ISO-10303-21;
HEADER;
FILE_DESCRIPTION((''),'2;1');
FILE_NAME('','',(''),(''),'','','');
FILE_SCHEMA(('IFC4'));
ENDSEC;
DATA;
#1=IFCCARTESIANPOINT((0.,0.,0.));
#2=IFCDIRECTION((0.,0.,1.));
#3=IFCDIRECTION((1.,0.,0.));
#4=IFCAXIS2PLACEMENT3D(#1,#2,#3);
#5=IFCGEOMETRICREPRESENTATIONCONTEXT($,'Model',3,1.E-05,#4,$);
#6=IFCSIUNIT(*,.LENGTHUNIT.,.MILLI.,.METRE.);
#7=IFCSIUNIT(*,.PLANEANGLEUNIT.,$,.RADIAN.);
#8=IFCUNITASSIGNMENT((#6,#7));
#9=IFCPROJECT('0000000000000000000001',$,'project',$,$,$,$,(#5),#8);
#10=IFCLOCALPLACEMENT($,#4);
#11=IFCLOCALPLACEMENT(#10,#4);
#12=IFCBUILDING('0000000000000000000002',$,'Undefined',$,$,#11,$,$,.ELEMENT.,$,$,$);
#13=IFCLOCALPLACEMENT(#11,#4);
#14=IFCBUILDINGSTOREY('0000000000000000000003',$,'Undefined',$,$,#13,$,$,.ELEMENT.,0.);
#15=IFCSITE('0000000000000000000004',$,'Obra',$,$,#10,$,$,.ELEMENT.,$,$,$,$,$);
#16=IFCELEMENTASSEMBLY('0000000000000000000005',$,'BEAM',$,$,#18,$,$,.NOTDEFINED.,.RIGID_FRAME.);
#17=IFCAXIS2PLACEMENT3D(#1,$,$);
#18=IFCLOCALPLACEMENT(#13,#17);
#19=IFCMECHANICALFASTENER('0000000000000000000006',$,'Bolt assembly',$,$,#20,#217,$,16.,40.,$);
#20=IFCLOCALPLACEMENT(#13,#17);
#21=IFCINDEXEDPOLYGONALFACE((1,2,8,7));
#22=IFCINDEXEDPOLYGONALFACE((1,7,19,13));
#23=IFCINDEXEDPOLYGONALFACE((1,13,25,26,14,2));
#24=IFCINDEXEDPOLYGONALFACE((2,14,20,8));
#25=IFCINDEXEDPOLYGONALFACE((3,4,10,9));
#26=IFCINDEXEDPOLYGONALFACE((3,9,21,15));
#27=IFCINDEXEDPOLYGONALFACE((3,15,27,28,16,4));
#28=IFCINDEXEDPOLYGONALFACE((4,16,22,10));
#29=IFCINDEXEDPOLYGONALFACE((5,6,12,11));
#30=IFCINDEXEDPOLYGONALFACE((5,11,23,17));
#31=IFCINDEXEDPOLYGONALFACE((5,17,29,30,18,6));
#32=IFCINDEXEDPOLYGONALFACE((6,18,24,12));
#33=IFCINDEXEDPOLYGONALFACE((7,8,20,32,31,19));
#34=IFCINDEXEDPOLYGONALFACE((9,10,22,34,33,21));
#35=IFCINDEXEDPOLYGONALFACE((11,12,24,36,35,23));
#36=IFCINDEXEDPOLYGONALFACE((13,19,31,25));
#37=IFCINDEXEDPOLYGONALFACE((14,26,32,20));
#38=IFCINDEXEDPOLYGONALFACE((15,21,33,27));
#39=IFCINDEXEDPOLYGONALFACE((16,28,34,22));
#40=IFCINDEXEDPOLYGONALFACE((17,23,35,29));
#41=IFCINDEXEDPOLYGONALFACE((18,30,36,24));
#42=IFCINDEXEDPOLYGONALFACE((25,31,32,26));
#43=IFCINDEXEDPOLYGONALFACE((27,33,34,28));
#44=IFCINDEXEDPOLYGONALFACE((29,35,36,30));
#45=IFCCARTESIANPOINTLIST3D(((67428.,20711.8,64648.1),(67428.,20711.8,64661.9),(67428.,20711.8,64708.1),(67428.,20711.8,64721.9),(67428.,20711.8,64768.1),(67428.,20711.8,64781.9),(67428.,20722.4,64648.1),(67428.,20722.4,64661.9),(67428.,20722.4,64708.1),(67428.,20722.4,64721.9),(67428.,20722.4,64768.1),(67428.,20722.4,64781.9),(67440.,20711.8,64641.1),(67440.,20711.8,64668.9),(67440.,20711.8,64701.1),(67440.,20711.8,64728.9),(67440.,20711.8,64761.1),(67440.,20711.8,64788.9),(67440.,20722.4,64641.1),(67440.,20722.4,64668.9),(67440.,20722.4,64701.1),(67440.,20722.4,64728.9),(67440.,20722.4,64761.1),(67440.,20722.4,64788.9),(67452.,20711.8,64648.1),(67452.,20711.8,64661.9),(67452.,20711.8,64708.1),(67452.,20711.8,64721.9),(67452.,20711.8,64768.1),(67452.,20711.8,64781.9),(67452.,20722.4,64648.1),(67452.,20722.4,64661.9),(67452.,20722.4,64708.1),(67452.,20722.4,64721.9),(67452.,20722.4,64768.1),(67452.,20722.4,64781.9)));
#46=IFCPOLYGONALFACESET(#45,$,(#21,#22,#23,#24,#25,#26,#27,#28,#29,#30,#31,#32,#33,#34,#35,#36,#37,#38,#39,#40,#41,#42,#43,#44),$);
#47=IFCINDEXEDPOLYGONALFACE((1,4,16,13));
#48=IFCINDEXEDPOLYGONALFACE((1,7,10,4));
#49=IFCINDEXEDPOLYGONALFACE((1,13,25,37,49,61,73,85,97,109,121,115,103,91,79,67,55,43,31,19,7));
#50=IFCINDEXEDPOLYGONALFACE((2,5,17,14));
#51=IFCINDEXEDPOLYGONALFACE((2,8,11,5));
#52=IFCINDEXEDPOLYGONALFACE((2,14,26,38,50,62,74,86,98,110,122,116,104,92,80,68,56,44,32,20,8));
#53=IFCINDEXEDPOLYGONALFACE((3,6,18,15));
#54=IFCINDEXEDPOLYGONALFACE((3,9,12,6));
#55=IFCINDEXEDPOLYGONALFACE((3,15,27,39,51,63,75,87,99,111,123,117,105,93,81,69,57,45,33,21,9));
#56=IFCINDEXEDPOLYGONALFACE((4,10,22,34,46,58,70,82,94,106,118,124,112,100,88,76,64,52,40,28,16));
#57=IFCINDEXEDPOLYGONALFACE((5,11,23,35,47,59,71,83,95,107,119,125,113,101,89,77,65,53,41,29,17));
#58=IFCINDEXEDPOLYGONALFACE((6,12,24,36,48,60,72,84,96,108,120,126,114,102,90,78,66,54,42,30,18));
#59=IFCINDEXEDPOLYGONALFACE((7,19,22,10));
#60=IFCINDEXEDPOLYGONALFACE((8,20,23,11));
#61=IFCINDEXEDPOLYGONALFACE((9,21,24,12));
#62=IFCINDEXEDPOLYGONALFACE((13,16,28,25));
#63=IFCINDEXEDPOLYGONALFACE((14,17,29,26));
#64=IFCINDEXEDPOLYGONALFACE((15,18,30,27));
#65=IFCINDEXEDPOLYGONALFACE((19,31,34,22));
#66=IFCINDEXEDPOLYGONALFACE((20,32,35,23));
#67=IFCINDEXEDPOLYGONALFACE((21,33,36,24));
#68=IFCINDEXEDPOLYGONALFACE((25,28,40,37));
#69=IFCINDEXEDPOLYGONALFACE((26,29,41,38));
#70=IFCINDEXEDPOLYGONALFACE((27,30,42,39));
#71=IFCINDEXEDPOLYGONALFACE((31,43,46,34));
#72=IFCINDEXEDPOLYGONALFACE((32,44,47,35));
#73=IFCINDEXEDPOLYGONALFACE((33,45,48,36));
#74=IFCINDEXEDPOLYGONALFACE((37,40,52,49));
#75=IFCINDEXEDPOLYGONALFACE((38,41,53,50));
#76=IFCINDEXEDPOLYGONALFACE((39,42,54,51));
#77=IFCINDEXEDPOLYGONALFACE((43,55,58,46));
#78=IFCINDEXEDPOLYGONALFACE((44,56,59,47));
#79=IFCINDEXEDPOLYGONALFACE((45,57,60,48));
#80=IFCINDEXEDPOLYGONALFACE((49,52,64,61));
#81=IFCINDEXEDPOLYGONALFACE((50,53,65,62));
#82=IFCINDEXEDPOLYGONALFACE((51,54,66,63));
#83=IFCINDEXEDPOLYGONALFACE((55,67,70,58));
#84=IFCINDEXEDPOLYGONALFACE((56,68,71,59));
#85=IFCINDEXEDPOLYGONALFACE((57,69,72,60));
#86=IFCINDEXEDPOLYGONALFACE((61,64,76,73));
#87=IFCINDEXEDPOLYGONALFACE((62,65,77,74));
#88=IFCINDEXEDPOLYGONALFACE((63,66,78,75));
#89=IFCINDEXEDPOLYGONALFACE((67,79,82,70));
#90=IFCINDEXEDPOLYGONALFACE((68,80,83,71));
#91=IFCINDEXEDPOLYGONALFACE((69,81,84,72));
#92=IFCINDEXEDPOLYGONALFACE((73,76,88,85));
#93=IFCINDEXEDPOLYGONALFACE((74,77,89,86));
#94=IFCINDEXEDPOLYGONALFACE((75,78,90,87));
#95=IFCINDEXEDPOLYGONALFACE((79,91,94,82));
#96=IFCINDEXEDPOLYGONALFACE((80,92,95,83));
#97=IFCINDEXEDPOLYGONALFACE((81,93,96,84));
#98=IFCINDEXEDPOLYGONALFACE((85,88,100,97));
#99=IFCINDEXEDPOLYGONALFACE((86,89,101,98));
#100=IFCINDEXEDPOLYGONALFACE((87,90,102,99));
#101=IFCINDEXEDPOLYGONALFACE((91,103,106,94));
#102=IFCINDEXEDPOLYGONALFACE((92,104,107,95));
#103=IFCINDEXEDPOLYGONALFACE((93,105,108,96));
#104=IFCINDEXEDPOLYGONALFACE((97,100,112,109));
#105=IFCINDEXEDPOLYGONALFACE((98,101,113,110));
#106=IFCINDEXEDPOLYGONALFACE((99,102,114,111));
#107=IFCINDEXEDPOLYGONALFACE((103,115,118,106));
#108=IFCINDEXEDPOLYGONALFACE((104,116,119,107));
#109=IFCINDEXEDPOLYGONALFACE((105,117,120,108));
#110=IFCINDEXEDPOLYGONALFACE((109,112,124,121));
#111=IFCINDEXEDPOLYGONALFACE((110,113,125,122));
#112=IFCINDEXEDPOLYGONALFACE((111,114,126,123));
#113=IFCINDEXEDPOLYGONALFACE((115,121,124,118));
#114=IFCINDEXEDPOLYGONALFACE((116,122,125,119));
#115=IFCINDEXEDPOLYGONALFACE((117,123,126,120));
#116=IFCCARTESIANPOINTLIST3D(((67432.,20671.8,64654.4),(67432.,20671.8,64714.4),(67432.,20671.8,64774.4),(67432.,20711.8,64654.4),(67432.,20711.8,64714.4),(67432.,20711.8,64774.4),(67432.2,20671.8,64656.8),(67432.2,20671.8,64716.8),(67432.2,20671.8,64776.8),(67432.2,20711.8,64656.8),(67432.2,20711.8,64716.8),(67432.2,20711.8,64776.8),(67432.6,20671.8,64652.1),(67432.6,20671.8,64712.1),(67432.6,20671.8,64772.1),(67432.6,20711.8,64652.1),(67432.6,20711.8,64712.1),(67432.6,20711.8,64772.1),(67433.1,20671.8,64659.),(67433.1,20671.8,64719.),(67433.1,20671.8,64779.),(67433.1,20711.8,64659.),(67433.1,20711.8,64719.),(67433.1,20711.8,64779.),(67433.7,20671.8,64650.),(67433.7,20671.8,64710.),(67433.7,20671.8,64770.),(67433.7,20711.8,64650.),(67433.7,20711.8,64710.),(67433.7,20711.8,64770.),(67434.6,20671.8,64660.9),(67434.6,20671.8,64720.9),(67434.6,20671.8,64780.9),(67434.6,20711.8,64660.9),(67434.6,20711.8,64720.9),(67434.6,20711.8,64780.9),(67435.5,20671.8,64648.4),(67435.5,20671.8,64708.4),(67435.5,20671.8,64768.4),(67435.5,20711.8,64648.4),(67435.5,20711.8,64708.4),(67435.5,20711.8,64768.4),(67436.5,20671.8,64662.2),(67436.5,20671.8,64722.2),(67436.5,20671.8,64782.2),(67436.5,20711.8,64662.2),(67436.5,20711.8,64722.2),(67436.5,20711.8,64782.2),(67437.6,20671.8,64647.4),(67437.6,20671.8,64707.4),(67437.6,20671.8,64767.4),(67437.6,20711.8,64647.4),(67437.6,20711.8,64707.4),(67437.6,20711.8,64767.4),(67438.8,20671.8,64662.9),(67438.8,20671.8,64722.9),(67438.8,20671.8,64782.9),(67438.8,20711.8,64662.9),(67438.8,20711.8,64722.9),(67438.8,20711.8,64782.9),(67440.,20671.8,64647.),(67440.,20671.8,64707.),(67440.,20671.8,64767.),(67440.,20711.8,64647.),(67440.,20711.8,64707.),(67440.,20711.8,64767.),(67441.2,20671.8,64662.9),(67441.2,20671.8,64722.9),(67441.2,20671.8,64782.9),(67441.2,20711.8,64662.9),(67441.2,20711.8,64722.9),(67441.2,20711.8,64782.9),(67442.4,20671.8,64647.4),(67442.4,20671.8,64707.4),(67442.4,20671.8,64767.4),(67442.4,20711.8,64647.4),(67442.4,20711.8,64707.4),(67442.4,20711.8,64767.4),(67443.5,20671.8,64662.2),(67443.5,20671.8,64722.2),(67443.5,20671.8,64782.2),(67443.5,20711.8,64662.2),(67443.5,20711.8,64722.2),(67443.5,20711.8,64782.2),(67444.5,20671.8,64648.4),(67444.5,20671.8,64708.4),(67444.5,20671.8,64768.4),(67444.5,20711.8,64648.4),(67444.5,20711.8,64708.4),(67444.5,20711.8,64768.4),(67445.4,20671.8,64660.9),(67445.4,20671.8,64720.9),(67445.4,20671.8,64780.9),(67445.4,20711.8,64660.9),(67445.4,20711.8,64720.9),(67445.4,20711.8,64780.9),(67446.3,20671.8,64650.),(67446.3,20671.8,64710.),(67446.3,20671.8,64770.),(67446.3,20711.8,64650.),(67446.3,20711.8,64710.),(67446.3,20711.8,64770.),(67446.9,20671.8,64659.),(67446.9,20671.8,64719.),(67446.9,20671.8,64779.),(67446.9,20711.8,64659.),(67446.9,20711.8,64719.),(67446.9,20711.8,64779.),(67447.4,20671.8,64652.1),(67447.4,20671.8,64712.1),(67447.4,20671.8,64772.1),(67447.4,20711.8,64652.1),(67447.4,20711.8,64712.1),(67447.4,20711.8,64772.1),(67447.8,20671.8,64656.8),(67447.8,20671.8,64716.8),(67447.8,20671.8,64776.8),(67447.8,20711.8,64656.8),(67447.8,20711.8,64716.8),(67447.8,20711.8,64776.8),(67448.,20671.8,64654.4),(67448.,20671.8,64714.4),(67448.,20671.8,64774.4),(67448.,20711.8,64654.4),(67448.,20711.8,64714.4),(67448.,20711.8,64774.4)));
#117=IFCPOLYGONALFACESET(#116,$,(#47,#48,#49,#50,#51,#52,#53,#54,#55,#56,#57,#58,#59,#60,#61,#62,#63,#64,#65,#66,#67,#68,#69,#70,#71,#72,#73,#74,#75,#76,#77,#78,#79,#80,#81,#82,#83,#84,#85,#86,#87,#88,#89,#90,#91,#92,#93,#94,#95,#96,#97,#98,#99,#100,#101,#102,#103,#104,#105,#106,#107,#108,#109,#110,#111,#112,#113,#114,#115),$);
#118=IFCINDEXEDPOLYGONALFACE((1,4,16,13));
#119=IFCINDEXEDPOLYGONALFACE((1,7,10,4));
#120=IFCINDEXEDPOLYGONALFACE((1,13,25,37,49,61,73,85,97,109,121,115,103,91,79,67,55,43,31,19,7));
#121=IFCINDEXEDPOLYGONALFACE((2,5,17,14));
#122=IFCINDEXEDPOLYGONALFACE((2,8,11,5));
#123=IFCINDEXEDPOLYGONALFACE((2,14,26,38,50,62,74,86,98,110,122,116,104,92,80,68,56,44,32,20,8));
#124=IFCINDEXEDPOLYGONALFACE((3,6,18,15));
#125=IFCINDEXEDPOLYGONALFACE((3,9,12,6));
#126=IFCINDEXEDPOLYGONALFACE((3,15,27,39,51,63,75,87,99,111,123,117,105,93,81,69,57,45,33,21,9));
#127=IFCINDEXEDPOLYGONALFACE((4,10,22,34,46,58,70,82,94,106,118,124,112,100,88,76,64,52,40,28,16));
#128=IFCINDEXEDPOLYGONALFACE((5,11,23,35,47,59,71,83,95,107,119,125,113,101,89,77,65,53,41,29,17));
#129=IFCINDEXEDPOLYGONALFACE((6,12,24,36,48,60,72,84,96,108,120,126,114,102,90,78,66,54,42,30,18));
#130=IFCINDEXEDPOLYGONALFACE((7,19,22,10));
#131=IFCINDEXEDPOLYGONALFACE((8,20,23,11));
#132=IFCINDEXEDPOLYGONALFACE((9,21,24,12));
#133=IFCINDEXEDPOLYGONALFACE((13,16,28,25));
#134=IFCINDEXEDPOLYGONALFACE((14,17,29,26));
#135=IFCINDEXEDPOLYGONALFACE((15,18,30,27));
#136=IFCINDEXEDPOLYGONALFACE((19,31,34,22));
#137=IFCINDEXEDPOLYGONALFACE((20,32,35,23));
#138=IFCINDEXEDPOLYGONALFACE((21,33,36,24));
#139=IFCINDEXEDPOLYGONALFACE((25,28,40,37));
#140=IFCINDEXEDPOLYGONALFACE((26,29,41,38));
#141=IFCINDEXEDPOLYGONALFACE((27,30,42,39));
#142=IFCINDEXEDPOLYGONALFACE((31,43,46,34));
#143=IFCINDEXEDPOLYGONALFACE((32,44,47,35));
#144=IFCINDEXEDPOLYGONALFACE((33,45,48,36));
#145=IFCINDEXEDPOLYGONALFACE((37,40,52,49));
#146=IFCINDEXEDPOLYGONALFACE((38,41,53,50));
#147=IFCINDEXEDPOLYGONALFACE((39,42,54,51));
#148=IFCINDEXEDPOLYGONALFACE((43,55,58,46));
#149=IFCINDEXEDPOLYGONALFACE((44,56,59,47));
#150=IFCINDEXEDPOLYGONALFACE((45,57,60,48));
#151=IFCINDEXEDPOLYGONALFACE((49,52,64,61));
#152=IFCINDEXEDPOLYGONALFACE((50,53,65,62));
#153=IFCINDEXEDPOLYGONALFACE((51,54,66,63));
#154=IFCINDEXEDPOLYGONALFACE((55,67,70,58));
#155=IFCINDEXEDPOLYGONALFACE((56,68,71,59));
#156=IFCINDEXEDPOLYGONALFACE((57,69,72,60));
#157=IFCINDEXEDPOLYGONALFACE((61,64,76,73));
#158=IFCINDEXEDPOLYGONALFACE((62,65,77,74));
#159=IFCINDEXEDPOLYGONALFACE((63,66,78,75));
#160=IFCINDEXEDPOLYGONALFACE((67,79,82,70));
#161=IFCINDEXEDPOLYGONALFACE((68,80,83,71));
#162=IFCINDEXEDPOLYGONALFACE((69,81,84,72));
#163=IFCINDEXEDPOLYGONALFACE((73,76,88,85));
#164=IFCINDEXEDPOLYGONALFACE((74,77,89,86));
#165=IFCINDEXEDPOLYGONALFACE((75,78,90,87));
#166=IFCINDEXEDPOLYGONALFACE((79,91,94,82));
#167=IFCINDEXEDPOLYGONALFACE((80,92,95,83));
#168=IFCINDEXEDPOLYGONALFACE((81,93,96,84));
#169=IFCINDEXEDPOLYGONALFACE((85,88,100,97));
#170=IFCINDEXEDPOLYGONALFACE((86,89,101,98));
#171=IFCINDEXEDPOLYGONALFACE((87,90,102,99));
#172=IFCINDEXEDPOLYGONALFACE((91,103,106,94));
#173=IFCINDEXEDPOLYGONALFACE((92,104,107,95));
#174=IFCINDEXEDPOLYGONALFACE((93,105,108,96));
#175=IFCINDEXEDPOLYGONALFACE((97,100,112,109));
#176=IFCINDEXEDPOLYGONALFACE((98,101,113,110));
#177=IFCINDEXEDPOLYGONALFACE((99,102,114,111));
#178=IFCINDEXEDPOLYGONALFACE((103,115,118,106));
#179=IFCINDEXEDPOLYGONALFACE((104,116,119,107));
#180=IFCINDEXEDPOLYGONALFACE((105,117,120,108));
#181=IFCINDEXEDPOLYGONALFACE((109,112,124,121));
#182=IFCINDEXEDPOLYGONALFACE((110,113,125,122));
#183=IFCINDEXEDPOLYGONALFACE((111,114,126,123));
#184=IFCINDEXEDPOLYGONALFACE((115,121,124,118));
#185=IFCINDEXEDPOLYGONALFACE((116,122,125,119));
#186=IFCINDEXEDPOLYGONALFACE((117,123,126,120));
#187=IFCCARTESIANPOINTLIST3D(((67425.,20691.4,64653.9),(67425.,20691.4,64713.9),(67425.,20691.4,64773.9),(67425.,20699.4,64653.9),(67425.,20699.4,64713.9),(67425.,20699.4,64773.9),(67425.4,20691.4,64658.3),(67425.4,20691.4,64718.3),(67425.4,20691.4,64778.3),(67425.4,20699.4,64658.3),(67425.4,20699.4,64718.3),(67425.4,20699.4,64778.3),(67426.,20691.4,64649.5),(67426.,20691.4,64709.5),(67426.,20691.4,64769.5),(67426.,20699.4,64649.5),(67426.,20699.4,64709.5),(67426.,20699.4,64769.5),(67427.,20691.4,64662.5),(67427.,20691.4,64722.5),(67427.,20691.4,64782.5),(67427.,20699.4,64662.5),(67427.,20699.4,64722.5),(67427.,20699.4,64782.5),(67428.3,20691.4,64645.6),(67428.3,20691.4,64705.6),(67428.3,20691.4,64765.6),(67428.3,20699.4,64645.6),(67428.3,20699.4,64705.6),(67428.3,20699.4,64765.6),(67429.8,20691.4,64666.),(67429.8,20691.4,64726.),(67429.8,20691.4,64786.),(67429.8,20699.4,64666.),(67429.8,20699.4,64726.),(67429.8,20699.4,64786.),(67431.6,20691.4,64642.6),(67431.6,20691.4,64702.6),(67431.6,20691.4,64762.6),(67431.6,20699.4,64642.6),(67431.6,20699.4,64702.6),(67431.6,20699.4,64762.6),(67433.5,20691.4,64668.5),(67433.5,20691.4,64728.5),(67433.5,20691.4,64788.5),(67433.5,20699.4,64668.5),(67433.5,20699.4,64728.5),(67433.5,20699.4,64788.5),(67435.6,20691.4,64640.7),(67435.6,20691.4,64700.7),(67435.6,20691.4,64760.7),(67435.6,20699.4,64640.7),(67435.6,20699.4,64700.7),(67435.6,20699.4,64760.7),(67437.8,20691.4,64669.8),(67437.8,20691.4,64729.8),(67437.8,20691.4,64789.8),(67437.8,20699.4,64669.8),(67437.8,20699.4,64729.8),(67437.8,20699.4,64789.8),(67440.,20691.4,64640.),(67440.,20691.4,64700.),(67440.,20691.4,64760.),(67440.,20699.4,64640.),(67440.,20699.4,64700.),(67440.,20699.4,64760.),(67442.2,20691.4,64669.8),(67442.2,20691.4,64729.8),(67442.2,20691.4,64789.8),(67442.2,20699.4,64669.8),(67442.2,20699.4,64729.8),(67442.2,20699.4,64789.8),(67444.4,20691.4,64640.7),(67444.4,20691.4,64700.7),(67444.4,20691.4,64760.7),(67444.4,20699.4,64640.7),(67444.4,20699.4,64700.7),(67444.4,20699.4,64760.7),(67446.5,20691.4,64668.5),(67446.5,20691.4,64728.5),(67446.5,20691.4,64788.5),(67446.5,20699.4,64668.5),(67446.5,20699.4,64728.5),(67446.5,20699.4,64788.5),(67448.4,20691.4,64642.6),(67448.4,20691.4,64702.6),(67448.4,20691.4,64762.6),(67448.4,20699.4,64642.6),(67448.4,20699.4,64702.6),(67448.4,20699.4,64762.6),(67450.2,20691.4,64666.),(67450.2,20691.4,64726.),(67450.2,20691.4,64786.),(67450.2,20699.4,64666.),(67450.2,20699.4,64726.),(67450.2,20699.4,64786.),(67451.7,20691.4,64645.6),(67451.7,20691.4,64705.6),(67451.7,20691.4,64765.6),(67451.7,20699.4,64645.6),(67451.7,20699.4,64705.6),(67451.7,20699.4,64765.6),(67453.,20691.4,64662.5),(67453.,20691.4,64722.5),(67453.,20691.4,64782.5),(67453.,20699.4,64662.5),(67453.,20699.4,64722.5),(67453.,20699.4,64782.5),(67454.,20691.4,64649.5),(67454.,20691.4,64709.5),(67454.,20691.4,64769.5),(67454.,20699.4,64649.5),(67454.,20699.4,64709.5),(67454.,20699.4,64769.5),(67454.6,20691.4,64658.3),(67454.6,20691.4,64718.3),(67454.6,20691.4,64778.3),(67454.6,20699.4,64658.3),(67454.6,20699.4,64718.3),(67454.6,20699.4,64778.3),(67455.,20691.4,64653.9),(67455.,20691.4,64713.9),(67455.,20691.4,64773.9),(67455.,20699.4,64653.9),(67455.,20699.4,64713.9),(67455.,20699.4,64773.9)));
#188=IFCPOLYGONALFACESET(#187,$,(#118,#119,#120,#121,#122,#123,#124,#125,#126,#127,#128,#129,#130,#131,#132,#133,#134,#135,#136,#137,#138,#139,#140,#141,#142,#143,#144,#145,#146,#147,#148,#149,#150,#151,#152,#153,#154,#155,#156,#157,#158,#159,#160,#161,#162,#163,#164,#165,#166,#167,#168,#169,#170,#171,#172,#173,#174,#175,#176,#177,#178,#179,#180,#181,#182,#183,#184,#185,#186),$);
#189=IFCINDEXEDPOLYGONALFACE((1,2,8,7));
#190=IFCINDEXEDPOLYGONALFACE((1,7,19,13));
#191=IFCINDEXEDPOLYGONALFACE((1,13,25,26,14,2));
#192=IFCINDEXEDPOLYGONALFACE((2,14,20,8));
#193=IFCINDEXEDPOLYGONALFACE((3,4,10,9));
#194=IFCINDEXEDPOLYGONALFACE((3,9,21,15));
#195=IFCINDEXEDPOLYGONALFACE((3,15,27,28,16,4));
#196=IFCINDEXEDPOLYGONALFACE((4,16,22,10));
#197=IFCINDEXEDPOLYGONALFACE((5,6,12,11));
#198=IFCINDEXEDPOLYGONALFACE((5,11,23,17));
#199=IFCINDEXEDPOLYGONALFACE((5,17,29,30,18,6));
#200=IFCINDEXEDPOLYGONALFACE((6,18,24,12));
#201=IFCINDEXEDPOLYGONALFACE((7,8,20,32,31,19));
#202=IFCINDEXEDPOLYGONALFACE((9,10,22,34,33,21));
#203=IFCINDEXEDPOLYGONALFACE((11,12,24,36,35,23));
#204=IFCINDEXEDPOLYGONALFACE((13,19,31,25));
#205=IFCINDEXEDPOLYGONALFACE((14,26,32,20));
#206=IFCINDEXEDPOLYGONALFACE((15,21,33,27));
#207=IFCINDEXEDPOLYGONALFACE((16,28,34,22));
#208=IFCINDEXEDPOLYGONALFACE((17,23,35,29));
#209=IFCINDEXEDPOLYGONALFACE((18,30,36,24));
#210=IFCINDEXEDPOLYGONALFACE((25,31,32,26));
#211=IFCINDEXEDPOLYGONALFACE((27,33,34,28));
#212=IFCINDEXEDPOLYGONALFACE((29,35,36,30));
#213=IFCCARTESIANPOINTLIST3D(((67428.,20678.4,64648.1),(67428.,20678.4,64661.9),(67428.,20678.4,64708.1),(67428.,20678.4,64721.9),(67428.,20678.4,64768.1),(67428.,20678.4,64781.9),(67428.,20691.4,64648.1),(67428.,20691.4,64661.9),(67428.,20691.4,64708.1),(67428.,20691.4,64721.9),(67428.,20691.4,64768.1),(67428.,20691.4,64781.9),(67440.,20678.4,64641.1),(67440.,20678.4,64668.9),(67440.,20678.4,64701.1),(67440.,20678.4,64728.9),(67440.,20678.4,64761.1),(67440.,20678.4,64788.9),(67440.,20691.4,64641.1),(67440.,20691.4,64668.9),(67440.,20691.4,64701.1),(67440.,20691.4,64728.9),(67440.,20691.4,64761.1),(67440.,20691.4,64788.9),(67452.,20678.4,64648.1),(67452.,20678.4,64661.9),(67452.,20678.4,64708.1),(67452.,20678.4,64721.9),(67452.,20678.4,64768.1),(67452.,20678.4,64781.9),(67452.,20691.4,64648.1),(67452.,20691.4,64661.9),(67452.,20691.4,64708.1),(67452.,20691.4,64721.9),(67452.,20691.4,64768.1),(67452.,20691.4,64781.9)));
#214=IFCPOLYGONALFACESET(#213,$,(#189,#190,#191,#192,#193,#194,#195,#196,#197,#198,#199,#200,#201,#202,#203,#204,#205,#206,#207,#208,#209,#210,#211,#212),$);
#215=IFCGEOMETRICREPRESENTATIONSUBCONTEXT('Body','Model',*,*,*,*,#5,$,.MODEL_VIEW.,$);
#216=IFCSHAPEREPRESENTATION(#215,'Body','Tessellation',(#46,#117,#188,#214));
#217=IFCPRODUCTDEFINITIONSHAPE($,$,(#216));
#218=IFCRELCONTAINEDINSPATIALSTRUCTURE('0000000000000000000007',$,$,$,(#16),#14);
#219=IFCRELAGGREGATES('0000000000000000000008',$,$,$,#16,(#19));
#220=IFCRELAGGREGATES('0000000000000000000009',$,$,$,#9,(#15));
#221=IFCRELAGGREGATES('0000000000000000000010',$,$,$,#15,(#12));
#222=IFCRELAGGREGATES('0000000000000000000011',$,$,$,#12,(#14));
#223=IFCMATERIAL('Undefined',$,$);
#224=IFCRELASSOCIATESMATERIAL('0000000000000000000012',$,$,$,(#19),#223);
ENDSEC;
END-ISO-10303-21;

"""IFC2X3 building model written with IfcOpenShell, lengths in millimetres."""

from ifc_helpers import new_model, si_unit, frame, origin_with_axes, origin_2d_with_axis, place, context, subcontext, project, spatial, polyline, circle, outline, extrude, source, transform, mapped, material, element, aggregate, save


model = new_model("IFC2X3")

# Units and contexts
model_context = context("Model", 3, precision=1e-05, world=origin_with_axes())
body_context = subcontext(model_context, "Body", "Model", "MODEL_VIEW")
ifc_project = project(units=[si_unit("LENGTHUNIT", "METRE", prefix="MILLI"), si_unit("PLANEANGLEUNIT", "RADIAN")], contexts=[model_context])

# Site, building, storey
site_placement = place(None, origin_with_axes())
site = spatial("IfcSite", under=ifc_project, at=site_placement, Name="Obra", CompositionType="ELEMENT")
building_placement = place(site_placement, origin_with_axes())
building = spatial("IfcBuilding", under=site, at=building_placement, Name="Undefined", CompositionType="ELEMENT")
storey_placement = place(building_placement, origin_with_axes())
storey = spatial("IfcBuildingStorey", under=building, at=storey_placement, Name="Undefined", CompositionType="ELEMENT", Elevation=0.0)

# Shared definitions
ifc_material_1 = material(Name="Undefined")

# Element assembly, mechanical fastener
assembly_1_placement = place(storey_placement, origin_with_axes())
assembly_1 = element("IfcElementAssembly", 1, at=assembly_1_placement, inside=storey, Name="BEAM", AssemblyPlace="NOTDEFINED", PredefinedType="RIGID_FRAME")
shared_shape_1 = source(origin_with_axes(), body_context, "Body", "SweptSolid", [
    extrude(outline(polyline([(13.9, 0.0), (6.9, 12.0), (-6.9, 12.0), (-13.9, 0.0), (-6.9, -12.0), (6.9, -12.0), (13.9, 0.0)])), frame((0.0, -19.7, 0.0), z_axis=(0.0, 1.0, 0.0), x_axis=(1.0, 0.0, 0.0)), (0.0, 0.0, 1.0), 10.6),
    extrude(circle(Radius=8.0, at=origin_2d_with_axis()), frame((0.0, -9.1, 0.0), z_axis=(0.0, 1.0, 0.0), x_axis=(1.0, 0.0, 0.0)), (0.0, 0.0, 1.0), 40.0),
    extrude(circle(Radius=15.0, at=origin_2d_with_axis()), frame((0.0, 3.3, 0.0), z_axis=(0.0, 1.0, 0.0), x_axis=(1.0, 0.0, 0.0)), (0.0, 0.0, 1.0), 8.0),
    extrude(outline(polyline([(13.9, 0.0), (6.9, 12.0), (-6.9, 12.0), (-13.9, 0.0), (-6.9, -12.0), (6.9, -12.0), (13.9, 0.0)])), frame((0.0, 11.3, 0.0), z_axis=(0.0, 1.0, 0.0), x_axis=(1.0, 0.0, 0.0)), (0.0, 0.0, 1.0), 13.0),
])
mechanical_fastener_1_placement = place(assembly_1_placement, frame((67490.0, 20702.7, 64835.0), z_axis=(-1.0, 0.0, 0.0), x_axis=(0.0, 0.0, -1.0)))
mechanical_fastener_1 = element("IfcMechanicalFastener", 2, at=mechanical_fastener_1_placement, material=ifc_material_1, Name="Bolt assembly", NominalDiameter=16.0, NominalLength=40.0, context=body_context, shape_type="MappedRepresentation", body=[
    mapped(shared_shape_1, transform((60.0, 0.0, 50.0))),
    mapped(shared_shape_1, transform((120.0, 0.0, 50.0))),
    mapped(shared_shape_1, transform((180.0, 0.0, 50.0))),
])
aggregate(assembly_1, [mechanical_fastener_1])

save(model, "model.ifc")
